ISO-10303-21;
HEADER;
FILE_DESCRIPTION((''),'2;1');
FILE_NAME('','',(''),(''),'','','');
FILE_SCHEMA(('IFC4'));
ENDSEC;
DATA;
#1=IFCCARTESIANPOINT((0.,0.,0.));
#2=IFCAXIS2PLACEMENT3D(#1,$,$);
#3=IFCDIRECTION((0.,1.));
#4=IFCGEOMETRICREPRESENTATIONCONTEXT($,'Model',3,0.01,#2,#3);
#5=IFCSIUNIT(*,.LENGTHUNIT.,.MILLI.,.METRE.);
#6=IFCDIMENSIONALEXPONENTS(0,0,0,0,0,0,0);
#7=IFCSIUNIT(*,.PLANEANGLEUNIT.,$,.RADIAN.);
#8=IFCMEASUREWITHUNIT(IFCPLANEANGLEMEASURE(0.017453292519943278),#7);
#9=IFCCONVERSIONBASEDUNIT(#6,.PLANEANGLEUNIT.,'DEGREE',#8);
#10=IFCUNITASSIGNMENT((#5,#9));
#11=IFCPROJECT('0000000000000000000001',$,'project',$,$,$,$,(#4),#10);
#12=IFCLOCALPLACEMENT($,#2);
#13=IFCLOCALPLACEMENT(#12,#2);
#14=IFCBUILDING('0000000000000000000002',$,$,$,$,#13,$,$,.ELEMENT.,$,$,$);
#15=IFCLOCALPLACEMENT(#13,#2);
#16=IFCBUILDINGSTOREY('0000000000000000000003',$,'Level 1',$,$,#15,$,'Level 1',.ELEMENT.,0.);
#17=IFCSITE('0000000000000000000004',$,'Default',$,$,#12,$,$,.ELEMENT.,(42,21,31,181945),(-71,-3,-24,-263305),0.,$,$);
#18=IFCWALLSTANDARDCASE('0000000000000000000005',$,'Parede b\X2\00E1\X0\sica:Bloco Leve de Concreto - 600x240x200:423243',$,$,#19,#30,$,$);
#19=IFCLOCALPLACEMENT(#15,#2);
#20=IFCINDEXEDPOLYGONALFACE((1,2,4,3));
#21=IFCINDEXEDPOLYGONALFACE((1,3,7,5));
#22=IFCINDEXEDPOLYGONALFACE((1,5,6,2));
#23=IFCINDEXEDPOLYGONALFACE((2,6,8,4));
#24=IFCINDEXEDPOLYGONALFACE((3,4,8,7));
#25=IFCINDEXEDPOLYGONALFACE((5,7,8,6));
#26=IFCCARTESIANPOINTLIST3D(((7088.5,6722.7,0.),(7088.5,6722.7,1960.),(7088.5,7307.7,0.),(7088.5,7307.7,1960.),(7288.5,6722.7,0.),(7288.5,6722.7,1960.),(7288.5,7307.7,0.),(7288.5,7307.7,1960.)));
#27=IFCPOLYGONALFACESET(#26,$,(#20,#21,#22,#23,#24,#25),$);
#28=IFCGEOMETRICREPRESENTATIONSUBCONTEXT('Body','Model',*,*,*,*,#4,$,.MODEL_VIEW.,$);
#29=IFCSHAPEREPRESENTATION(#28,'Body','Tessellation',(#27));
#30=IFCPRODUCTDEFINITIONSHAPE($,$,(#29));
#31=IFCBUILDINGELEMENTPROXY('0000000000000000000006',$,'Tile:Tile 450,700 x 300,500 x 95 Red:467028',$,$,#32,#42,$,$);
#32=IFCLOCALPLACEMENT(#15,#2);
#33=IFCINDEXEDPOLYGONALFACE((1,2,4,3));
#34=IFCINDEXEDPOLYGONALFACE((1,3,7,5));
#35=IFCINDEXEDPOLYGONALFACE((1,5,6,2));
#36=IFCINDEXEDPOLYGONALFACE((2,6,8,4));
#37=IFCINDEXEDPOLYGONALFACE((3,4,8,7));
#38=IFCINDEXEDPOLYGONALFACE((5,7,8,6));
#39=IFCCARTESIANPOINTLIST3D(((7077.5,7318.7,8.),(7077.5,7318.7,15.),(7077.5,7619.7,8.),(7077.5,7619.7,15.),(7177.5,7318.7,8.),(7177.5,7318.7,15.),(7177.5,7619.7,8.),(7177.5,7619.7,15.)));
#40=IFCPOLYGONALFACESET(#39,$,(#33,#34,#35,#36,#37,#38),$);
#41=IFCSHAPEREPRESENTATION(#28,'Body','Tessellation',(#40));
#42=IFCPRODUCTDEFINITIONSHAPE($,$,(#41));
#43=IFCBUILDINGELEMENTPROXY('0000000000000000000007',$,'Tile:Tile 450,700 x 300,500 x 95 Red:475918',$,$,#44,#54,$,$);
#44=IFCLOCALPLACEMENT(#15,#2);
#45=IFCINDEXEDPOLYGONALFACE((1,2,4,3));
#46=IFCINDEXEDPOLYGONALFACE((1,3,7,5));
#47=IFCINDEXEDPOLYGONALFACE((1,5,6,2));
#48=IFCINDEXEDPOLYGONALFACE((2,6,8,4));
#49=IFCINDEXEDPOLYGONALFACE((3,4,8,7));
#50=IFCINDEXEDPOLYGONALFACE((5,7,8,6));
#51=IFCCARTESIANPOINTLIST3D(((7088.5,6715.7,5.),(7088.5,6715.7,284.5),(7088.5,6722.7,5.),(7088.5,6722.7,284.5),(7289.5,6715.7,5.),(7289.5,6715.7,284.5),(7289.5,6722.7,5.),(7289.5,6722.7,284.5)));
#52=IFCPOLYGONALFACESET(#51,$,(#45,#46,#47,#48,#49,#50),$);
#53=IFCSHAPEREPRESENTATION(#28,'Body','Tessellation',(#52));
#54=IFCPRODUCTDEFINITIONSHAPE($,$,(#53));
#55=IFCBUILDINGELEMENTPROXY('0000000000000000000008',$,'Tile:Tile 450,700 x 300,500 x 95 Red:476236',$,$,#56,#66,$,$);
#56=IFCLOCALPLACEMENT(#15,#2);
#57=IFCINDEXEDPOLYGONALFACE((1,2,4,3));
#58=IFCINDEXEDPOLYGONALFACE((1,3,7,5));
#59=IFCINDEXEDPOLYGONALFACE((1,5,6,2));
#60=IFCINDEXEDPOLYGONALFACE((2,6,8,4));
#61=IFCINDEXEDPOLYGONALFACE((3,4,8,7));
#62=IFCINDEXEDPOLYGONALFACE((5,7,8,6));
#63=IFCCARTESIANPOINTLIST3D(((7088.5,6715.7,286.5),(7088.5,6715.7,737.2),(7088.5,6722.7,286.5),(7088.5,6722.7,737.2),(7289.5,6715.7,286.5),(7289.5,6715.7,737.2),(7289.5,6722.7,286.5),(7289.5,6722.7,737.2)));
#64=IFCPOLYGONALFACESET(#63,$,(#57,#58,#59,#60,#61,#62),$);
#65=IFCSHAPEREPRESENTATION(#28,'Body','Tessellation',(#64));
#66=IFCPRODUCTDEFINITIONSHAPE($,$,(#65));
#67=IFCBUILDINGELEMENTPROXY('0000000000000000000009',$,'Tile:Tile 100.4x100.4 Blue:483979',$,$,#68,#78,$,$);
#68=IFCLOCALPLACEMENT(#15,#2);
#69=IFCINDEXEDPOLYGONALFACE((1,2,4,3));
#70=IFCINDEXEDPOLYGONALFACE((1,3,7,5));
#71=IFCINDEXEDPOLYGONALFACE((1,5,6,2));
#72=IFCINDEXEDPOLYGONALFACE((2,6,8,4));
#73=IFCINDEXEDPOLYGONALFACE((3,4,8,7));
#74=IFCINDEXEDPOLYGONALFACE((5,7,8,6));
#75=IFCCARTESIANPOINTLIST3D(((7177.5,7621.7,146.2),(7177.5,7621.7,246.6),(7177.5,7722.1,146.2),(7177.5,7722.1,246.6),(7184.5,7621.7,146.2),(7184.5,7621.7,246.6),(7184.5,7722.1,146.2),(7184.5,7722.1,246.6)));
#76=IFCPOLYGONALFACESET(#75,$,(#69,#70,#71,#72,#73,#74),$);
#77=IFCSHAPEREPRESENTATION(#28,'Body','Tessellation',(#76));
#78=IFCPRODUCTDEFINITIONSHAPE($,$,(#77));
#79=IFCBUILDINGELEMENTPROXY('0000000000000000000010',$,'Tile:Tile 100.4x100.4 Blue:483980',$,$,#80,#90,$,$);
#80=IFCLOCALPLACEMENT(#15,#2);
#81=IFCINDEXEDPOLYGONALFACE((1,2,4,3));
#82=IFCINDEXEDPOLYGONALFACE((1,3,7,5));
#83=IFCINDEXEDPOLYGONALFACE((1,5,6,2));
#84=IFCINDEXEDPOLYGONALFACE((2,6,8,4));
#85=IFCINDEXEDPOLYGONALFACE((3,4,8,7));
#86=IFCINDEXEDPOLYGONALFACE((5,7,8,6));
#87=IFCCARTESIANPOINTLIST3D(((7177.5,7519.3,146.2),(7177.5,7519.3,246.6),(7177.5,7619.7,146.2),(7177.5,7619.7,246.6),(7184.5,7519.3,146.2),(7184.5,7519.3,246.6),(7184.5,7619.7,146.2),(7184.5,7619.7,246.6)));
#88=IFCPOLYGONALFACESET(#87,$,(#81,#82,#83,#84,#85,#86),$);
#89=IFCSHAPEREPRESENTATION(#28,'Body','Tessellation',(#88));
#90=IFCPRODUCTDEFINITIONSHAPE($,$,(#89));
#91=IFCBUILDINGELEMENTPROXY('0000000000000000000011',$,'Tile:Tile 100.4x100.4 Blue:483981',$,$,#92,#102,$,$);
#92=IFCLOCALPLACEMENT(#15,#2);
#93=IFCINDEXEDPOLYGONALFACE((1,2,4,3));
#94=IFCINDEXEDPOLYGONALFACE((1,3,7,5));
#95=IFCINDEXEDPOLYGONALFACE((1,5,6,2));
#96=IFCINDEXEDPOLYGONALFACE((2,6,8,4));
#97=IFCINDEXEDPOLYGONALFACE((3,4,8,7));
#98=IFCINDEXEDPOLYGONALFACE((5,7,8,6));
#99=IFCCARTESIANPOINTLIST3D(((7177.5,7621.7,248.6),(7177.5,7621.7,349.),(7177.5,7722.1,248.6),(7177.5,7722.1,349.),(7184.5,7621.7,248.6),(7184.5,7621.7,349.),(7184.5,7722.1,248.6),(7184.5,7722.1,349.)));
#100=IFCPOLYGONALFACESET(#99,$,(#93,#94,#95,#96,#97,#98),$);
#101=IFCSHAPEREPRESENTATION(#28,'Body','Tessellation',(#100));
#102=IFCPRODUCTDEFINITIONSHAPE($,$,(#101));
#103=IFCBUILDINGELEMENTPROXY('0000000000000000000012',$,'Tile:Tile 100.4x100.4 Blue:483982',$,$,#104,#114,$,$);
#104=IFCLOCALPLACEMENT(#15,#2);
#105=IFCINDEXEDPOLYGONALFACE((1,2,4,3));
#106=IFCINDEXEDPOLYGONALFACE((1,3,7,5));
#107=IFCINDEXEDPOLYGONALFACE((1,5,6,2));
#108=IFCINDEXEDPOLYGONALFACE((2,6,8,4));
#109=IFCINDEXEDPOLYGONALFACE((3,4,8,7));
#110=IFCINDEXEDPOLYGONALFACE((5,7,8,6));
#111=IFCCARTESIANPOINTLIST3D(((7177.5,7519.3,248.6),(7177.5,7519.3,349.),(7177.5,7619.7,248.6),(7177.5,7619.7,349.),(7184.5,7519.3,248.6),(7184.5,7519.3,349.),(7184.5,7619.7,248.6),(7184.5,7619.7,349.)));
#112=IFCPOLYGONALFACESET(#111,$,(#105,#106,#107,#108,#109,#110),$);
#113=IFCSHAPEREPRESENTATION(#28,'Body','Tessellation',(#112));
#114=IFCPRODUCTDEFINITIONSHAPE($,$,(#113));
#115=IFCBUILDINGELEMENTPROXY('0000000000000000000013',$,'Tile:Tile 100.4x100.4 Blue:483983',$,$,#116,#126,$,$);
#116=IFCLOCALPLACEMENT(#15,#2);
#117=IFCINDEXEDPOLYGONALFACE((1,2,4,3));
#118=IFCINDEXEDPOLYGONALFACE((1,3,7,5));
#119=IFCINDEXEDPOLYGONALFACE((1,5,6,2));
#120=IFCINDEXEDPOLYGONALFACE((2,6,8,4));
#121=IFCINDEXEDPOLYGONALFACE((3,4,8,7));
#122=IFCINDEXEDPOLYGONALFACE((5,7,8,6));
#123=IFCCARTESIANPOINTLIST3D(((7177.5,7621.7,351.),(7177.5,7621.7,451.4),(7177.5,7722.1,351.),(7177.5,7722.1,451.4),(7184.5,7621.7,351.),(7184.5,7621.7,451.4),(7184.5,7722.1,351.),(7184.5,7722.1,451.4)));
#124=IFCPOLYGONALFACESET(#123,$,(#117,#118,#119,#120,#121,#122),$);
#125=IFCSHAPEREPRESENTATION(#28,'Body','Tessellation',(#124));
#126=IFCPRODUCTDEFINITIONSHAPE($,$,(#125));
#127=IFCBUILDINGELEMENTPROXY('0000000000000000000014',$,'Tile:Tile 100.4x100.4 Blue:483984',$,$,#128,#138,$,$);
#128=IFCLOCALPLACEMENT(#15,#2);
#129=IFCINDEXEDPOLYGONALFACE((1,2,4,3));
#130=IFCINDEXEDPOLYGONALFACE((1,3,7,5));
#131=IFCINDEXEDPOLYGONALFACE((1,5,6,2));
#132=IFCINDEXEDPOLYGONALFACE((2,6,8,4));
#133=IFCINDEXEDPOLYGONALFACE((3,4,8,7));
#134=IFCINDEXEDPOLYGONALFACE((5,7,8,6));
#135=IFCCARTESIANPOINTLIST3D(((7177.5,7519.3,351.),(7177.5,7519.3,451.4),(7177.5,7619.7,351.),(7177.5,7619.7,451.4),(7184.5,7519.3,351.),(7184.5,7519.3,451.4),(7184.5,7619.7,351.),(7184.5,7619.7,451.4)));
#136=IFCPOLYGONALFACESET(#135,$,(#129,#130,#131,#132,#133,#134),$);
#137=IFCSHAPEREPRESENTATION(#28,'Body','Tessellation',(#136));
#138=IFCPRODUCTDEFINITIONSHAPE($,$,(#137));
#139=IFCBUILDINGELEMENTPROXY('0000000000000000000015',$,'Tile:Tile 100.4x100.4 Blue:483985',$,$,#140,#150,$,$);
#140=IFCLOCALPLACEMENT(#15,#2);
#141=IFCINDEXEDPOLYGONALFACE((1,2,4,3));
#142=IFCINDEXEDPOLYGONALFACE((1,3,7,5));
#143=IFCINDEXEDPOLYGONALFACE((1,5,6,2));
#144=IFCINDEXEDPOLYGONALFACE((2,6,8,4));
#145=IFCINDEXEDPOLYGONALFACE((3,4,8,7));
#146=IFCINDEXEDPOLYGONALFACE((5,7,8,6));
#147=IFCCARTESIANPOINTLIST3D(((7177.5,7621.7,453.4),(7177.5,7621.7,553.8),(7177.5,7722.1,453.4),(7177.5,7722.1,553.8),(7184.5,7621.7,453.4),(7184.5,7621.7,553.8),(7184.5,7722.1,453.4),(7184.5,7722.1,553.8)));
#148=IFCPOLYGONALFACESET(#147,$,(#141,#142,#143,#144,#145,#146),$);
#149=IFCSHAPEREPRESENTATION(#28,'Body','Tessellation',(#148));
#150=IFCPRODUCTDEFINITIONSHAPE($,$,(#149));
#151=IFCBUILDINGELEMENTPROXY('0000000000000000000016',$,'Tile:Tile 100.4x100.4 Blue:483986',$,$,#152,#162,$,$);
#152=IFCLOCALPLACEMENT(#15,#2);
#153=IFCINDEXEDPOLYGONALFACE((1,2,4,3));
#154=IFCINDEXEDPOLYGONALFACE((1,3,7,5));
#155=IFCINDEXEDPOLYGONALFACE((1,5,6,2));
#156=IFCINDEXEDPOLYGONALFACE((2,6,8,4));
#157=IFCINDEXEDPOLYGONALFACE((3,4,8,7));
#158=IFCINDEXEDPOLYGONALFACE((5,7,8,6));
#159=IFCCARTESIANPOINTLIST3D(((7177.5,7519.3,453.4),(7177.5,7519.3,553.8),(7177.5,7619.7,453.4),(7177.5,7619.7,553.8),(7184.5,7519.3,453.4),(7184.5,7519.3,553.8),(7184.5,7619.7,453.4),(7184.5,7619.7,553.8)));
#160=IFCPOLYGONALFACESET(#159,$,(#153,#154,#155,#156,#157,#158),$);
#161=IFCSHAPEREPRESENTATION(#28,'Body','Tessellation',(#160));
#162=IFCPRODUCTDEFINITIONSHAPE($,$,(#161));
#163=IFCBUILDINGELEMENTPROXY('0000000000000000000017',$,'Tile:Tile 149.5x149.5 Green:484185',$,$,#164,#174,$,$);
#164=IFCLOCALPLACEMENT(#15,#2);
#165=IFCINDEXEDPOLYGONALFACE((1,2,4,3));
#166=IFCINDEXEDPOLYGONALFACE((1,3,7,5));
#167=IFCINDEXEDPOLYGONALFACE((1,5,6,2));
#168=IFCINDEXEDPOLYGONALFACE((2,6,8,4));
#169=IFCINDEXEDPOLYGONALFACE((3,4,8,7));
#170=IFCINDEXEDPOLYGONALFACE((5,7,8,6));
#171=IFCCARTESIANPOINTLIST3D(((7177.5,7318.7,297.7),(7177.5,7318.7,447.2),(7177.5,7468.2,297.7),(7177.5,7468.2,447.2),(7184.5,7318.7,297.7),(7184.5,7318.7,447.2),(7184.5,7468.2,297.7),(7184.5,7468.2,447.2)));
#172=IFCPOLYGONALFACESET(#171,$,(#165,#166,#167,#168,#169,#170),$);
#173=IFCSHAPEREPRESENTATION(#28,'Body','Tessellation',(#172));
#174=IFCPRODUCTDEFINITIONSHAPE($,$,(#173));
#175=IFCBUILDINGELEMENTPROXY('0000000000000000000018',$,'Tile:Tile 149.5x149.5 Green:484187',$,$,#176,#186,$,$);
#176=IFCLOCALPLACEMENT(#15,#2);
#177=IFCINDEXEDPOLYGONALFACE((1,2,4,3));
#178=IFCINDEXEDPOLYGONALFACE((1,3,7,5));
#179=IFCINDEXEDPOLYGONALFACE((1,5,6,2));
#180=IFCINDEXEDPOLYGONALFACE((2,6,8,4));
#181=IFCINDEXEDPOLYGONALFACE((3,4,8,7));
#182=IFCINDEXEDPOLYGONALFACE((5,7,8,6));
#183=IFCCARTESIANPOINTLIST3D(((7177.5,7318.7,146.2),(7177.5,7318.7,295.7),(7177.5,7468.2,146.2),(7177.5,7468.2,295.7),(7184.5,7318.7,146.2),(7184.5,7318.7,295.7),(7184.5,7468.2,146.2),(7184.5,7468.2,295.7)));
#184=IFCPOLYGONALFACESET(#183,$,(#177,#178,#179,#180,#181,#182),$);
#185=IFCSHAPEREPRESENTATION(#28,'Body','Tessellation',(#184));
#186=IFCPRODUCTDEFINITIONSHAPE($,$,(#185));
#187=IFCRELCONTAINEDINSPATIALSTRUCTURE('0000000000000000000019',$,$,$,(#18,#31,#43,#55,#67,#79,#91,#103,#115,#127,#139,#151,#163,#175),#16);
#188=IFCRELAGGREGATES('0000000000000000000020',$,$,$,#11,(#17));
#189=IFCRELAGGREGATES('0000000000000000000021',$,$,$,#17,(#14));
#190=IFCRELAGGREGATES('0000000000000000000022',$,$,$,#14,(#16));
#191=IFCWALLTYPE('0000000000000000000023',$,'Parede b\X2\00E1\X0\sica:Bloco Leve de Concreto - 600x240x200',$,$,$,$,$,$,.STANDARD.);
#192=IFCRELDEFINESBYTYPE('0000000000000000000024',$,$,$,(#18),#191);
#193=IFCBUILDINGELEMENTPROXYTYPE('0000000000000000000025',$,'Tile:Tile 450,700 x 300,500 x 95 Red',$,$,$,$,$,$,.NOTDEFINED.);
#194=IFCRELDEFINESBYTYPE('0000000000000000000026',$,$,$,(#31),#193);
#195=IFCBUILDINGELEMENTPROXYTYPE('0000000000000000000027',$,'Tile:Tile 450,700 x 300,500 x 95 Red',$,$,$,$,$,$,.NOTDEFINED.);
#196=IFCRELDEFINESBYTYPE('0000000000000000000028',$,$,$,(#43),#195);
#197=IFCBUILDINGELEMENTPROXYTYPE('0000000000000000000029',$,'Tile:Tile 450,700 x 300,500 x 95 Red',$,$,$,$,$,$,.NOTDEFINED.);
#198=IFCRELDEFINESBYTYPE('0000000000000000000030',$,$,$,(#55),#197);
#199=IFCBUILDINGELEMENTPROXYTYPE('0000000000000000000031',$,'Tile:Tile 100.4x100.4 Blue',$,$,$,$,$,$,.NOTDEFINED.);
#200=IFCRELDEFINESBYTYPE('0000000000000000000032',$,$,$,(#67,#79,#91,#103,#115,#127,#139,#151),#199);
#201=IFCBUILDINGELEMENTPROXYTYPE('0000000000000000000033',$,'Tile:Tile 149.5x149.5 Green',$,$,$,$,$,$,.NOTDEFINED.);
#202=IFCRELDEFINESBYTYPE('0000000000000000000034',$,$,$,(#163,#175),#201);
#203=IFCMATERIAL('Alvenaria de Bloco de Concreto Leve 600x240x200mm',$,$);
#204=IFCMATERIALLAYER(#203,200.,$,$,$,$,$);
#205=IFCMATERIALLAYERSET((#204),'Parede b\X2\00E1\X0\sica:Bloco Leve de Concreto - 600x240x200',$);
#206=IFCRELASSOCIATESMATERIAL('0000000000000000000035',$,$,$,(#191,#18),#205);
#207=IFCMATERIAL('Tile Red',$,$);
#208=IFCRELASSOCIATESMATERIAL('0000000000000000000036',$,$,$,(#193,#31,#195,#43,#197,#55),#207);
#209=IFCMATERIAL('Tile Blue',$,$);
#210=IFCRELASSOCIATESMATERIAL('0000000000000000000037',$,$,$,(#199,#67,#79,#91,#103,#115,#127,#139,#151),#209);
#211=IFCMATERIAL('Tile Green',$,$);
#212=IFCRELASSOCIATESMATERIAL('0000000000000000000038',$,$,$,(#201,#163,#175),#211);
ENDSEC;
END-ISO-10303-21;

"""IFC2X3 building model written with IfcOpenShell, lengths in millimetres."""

from ifc_helpers import new_model, entity, si_unit, converted_unit, direction, frame, frame_2d, origin, origin_2d_with_axis, place, context, subcontext, project, spatial, rectangle, extrude, source, transform, mapped, material, layer, layer_set, layer_usage, type_object, type_shapes, element, save


model = new_model("IFC2X3")

# Units and contexts
model_context = context("Model", 3, precision=0.01, world=origin(), true_north=direction((0.0, 1.0)))
body_context = subcontext(model_context, "Body", "Model", "MODEL_VIEW")
ifc_project = project(units=[si_unit("LENGTHUNIT", "METRE", prefix="MILLI"), converted_unit("PLANEANGLEUNIT", "DEGREE", entity("IfcPlaneAngleMeasure", 0.017453292519943278), si_unit("PLANEANGLEUNIT", "RADIAN"), dimensions=[0, 0, 0, 0, 0, 0, 0])], contexts=[model_context])

# Site, building, storey
site_placement = place(None, origin())
site = spatial("IfcSite", under=ifc_project, at=site_placement, Name="Default", CompositionType="ELEMENT", RefLatitude=(42, 21, 31, 181945), RefLongitude=(-71, -3, -24, -263305), RefElevation=0.0)
building_placement = place(site_placement, origin())
building = spatial("IfcBuilding", under=site, at=building_placement, CompositionType="ELEMENT")
storey_placement = place(building_placement, origin())
storey = spatial("IfcBuildingStorey", under=building, at=storey_placement, Name="Level 1", LongName="Level 1", CompositionType="ELEMENT", Elevation=0.0)

# Wall
ifc_material_1 = material(Name="Alvenaria de Bloco de Concreto Leve 600x240x200mm")
ifc_layer = layer(ifc_material_1, 200.0)
ifc_layer_set = layer_set([ifc_layer], Name="Parede básica:Bloco Leve de Concreto - 600x240x200")
ifc_layer_usage = layer_usage(ifc_layer_set, "AXIS2", "NEGATIVE", 100.0)
wall_type = type_object("IfcWallType", Name="Parede básica:Bloco Leve de Concreto - 600x240x200", PredefinedType="STANDARD", material=ifc_layer_set)
wall_placement = place(storey_placement, frame((7188.5, 7307.7, 0.0), z_axis=(0.0, 0.0, 1.0), x_axis=(0.0, -1.0, 0.0)))
element("IfcWallStandardCase", 1, at=wall_placement, inside=storey, type_object=wall_type, material=ifc_layer_usage, Name="Parede básica:Bloco Leve de Concreto - 600x240x200:423243", context=body_context, shape_type="SweptSolid", body=[
    extrude(rectangle(XDim=585.0, YDim=200.0, at=frame_2d((292.5, 0.0), x_axis=(-1.0, 0.0))), origin(), (0.0, 0.0, 1.0), 1960.0),
])

# Building element proxies
ifc_material_2 = material(Name="Tile Red")
building_element_proxy_type_1 = type_object("IfcBuildingElementProxyType", Name="Tile:Tile 450,700 x 300,500 x 95 Red", PredefinedType="NOTDEFINED", material=ifc_material_2)
shared_shape_1 = source(origin(), body_context, "Body", "SweptSolid", [
    extrude(rectangle(XDim=100.0, YDim=301.0, at=frame_2d((0.0, 0.0), x_axis=(1.0, 0.0))), frame((-50.0, -150.5, 0.0), z_axis=(0.0, 0.0, 1.0), x_axis=(-1.0, 0.0, 0.0)), (0.0, 0.0, 1.0), 7.0),
])
type_shapes(building_element_proxy_type_1, [shared_shape_1])
proxy_1_placement = place(storey_placement, frame((7177.5, 7619.7, 8.0)))
element("IfcBuildingElementProxy", 2, at=proxy_1_placement, inside=storey, type_object=building_element_proxy_type_1, material=ifc_material_2, Name="Tile:Tile 450,700 x 300,500 x 95 Red:467028", context=body_context, shape_type="MappedRepresentation", body=[
    mapped(shared_shape_1, transform((0.0, 0.0, 0.0), scale=1.0)),
])
building_element_proxy_type_2 = type_object("IfcBuildingElementProxyType", Name="Tile:Tile 450,700 x 300,500 x 95 Red", PredefinedType="NOTDEFINED", material=ifc_material_2)
shared_shape_2 = source(origin(), body_context, "Body", "SweptSolid", [
    extrude(rectangle(XDim=201.0, YDim=279.5, at=frame_2d((0.0, 0.0), x_axis=(1.0, 0.0))), frame((-100.5, -139.7, 0.0), z_axis=(0.0, 0.0, 1.0), x_axis=(-1.0, 0.0, 0.0)), (0.0, 0.0, 1.0), 7.0),
])
type_shapes(building_element_proxy_type_2, [shared_shape_2])
proxy_2_placement = place(storey_placement, frame((7088.5, 6722.7, 5.0), z_axis=(0.0, -1.0, 0.0), x_axis=(-1.0, 0.0, 0.0)))
element("IfcBuildingElementProxy", 3, at=proxy_2_placement, inside=storey, type_object=building_element_proxy_type_2, material=ifc_material_2, Name="Tile:Tile 450,700 x 300,500 x 95 Red:475918", context=body_context, shape_type="MappedRepresentation", body=[
    mapped(shared_shape_2, transform((0.0, 0.0, 0.0), scale=1.0)),
])
building_element_proxy_type_3 = type_object("IfcBuildingElementProxyType", Name="Tile:Tile 450,700 x 300,500 x 95 Red", PredefinedType="NOTDEFINED", material=ifc_material_2)
shared_shape_3 = source(origin(), body_context, "Body", "SweptSolid", [
    extrude(rectangle(XDim=201.0, YDim=450.7, at=frame_2d((0.0, 0.0), x_axis=(1.0, 0.0))), frame((-100.5, -225.4, 0.0), z_axis=(0.0, 0.0, 1.0), x_axis=(-1.0, 0.0, 0.0)), (0.0, 0.0, 1.0), 7.0),
])
type_shapes(building_element_proxy_type_3, [shared_shape_3])
proxy_3_placement = place(storey_placement, frame((7088.5, 6722.7, 286.5), z_axis=(0.0, -1.0, 0.0), x_axis=(-1.0, 0.0, 0.0)))
element("IfcBuildingElementProxy", 4, at=proxy_3_placement, inside=storey, type_object=building_element_proxy_type_3, material=ifc_material_2, Name="Tile:Tile 450,700 x 300,500 x 95 Red:476236", context=body_context, shape_type="MappedRepresentation", body=[
    mapped(shared_shape_3, transform((0.0, 0.0, 0.0), scale=1.0)),
])
ifc_material_3 = material(Name="Tile Blue")
building_element_proxy_type_4 = type_object("IfcBuildingElementProxyType", Name="Tile:Tile 100.4x100.4 Blue", PredefinedType="NOTDEFINED", material=ifc_material_3)
shared_shape_4 = source(origin(), body_context, "Body", "SweptSolid", [
    extrude(rectangle(XDim=100.4, YDim=100.4, at=origin_2d_with_axis()), frame((-50.2, -50.2, 0.0), z_axis=(0.0, 0.0, 1.0), x_axis=(0.0, -1.0, 0.0)), (0.0, 0.0, 1.0), 7.0),
])
type_shapes(building_element_proxy_type_4, [shared_shape_4])
for number, where, z_axis, x_axis, name in (
    (5, (7184.5, 7722.1, 146.2), (-1.0, 0.0, 0.0), (0.0, 1.0, 0.0), "Tile:Tile 100.4x100.4 Blue:483979"),
    (6, (7184.5, 7619.7, 146.2), (-1.0, 0.0, 0.0), (0.0, 1.0, 0.0), "Tile:Tile 100.4x100.4 Blue:483980"),
    (7, (7184.5, 7722.1, 248.6), (-1.0, 0.0, 0.0), (0.0, 1.0, 0.0), "Tile:Tile 100.4x100.4 Blue:483981"),
    (8, (7184.5, 7619.7, 248.6), (-1.0, 0.0, 0.0), (0.0, 1.0, 0.0), "Tile:Tile 100.4x100.4 Blue:483982"),
    (9, (7184.5, 7722.1, 351.0), (-1.0, 0.0, 0.0), (0.0, 1.0, 0.0), "Tile:Tile 100.4x100.4 Blue:483983"),
    (10, (7184.5, 7619.7, 351.0), (-1.0, 0.0, 0.0), (0.0, 1.0, 0.0), "Tile:Tile 100.4x100.4 Blue:483984"),
    (11, (7184.5, 7722.1, 453.4), (-1.0, 0.0, 0.0), (0.0, 1.0, 0.0), "Tile:Tile 100.4x100.4 Blue:483985"),
    (12, (7184.5, 7619.7, 453.4), (-1.0, 0.0, 0.0), (0.0, 1.0, 0.0), "Tile:Tile 100.4x100.4 Blue:483986"),
):
    element("IfcBuildingElementProxy", number, at=place(storey_placement, frame(where, z_axis=z_axis, x_axis=x_axis)), inside=storey, type_object=building_element_proxy_type_4, material=ifc_material_3, Name=name, context=body_context, shape_type="MappedRepresentation", body=[
        mapped(shared_shape_4, transform((0.0, 0.0, 0.0), scale=1.0)),
    ])
ifc_material_4 = material(Name="Tile Green")
building_element_proxy_type_5 = type_object("IfcBuildingElementProxyType", Name="Tile:Tile 149.5x149.5 Green", PredefinedType="NOTDEFINED", material=ifc_material_4)
shared_shape_5 = source(origin(), body_context, "Body", "SweptSolid", [
    extrude(rectangle(XDim=149.5, YDim=149.5, at=origin_2d_with_axis()), frame((-74.7, -74.8, 0.0), z_axis=(0.0, 0.0, 1.0), x_axis=(0.0, -1.0, 0.0)), (0.0, 0.0, 1.0), 7.0),
])
type_shapes(building_element_proxy_type_5, [shared_shape_5])
for number, where, z_axis, x_axis, name in (
    (13, (7184.5, 7468.2, 447.2), (-1.0, 0.0, 0.0), (0.0, 0.0, 1.0), "Tile:Tile 149.5x149.5 Green:484185"),
    (14, (7184.5, 7468.2, 295.7), (-1.0, 0.0, 0.0), (0.0, 0.0, 1.0), "Tile:Tile 149.5x149.5 Green:484187"),
):
    element("IfcBuildingElementProxy", number, at=place(storey_placement, frame(where, z_axis=z_axis, x_axis=x_axis)), inside=storey, type_object=building_element_proxy_type_5, material=ifc_material_4, Name=name, context=body_context, shape_type="MappedRepresentation", body=[
        mapped(shared_shape_5, transform((0.0, 0.0, 0.0), scale=1.0)),
    ])

save(model, "model.ifc")
